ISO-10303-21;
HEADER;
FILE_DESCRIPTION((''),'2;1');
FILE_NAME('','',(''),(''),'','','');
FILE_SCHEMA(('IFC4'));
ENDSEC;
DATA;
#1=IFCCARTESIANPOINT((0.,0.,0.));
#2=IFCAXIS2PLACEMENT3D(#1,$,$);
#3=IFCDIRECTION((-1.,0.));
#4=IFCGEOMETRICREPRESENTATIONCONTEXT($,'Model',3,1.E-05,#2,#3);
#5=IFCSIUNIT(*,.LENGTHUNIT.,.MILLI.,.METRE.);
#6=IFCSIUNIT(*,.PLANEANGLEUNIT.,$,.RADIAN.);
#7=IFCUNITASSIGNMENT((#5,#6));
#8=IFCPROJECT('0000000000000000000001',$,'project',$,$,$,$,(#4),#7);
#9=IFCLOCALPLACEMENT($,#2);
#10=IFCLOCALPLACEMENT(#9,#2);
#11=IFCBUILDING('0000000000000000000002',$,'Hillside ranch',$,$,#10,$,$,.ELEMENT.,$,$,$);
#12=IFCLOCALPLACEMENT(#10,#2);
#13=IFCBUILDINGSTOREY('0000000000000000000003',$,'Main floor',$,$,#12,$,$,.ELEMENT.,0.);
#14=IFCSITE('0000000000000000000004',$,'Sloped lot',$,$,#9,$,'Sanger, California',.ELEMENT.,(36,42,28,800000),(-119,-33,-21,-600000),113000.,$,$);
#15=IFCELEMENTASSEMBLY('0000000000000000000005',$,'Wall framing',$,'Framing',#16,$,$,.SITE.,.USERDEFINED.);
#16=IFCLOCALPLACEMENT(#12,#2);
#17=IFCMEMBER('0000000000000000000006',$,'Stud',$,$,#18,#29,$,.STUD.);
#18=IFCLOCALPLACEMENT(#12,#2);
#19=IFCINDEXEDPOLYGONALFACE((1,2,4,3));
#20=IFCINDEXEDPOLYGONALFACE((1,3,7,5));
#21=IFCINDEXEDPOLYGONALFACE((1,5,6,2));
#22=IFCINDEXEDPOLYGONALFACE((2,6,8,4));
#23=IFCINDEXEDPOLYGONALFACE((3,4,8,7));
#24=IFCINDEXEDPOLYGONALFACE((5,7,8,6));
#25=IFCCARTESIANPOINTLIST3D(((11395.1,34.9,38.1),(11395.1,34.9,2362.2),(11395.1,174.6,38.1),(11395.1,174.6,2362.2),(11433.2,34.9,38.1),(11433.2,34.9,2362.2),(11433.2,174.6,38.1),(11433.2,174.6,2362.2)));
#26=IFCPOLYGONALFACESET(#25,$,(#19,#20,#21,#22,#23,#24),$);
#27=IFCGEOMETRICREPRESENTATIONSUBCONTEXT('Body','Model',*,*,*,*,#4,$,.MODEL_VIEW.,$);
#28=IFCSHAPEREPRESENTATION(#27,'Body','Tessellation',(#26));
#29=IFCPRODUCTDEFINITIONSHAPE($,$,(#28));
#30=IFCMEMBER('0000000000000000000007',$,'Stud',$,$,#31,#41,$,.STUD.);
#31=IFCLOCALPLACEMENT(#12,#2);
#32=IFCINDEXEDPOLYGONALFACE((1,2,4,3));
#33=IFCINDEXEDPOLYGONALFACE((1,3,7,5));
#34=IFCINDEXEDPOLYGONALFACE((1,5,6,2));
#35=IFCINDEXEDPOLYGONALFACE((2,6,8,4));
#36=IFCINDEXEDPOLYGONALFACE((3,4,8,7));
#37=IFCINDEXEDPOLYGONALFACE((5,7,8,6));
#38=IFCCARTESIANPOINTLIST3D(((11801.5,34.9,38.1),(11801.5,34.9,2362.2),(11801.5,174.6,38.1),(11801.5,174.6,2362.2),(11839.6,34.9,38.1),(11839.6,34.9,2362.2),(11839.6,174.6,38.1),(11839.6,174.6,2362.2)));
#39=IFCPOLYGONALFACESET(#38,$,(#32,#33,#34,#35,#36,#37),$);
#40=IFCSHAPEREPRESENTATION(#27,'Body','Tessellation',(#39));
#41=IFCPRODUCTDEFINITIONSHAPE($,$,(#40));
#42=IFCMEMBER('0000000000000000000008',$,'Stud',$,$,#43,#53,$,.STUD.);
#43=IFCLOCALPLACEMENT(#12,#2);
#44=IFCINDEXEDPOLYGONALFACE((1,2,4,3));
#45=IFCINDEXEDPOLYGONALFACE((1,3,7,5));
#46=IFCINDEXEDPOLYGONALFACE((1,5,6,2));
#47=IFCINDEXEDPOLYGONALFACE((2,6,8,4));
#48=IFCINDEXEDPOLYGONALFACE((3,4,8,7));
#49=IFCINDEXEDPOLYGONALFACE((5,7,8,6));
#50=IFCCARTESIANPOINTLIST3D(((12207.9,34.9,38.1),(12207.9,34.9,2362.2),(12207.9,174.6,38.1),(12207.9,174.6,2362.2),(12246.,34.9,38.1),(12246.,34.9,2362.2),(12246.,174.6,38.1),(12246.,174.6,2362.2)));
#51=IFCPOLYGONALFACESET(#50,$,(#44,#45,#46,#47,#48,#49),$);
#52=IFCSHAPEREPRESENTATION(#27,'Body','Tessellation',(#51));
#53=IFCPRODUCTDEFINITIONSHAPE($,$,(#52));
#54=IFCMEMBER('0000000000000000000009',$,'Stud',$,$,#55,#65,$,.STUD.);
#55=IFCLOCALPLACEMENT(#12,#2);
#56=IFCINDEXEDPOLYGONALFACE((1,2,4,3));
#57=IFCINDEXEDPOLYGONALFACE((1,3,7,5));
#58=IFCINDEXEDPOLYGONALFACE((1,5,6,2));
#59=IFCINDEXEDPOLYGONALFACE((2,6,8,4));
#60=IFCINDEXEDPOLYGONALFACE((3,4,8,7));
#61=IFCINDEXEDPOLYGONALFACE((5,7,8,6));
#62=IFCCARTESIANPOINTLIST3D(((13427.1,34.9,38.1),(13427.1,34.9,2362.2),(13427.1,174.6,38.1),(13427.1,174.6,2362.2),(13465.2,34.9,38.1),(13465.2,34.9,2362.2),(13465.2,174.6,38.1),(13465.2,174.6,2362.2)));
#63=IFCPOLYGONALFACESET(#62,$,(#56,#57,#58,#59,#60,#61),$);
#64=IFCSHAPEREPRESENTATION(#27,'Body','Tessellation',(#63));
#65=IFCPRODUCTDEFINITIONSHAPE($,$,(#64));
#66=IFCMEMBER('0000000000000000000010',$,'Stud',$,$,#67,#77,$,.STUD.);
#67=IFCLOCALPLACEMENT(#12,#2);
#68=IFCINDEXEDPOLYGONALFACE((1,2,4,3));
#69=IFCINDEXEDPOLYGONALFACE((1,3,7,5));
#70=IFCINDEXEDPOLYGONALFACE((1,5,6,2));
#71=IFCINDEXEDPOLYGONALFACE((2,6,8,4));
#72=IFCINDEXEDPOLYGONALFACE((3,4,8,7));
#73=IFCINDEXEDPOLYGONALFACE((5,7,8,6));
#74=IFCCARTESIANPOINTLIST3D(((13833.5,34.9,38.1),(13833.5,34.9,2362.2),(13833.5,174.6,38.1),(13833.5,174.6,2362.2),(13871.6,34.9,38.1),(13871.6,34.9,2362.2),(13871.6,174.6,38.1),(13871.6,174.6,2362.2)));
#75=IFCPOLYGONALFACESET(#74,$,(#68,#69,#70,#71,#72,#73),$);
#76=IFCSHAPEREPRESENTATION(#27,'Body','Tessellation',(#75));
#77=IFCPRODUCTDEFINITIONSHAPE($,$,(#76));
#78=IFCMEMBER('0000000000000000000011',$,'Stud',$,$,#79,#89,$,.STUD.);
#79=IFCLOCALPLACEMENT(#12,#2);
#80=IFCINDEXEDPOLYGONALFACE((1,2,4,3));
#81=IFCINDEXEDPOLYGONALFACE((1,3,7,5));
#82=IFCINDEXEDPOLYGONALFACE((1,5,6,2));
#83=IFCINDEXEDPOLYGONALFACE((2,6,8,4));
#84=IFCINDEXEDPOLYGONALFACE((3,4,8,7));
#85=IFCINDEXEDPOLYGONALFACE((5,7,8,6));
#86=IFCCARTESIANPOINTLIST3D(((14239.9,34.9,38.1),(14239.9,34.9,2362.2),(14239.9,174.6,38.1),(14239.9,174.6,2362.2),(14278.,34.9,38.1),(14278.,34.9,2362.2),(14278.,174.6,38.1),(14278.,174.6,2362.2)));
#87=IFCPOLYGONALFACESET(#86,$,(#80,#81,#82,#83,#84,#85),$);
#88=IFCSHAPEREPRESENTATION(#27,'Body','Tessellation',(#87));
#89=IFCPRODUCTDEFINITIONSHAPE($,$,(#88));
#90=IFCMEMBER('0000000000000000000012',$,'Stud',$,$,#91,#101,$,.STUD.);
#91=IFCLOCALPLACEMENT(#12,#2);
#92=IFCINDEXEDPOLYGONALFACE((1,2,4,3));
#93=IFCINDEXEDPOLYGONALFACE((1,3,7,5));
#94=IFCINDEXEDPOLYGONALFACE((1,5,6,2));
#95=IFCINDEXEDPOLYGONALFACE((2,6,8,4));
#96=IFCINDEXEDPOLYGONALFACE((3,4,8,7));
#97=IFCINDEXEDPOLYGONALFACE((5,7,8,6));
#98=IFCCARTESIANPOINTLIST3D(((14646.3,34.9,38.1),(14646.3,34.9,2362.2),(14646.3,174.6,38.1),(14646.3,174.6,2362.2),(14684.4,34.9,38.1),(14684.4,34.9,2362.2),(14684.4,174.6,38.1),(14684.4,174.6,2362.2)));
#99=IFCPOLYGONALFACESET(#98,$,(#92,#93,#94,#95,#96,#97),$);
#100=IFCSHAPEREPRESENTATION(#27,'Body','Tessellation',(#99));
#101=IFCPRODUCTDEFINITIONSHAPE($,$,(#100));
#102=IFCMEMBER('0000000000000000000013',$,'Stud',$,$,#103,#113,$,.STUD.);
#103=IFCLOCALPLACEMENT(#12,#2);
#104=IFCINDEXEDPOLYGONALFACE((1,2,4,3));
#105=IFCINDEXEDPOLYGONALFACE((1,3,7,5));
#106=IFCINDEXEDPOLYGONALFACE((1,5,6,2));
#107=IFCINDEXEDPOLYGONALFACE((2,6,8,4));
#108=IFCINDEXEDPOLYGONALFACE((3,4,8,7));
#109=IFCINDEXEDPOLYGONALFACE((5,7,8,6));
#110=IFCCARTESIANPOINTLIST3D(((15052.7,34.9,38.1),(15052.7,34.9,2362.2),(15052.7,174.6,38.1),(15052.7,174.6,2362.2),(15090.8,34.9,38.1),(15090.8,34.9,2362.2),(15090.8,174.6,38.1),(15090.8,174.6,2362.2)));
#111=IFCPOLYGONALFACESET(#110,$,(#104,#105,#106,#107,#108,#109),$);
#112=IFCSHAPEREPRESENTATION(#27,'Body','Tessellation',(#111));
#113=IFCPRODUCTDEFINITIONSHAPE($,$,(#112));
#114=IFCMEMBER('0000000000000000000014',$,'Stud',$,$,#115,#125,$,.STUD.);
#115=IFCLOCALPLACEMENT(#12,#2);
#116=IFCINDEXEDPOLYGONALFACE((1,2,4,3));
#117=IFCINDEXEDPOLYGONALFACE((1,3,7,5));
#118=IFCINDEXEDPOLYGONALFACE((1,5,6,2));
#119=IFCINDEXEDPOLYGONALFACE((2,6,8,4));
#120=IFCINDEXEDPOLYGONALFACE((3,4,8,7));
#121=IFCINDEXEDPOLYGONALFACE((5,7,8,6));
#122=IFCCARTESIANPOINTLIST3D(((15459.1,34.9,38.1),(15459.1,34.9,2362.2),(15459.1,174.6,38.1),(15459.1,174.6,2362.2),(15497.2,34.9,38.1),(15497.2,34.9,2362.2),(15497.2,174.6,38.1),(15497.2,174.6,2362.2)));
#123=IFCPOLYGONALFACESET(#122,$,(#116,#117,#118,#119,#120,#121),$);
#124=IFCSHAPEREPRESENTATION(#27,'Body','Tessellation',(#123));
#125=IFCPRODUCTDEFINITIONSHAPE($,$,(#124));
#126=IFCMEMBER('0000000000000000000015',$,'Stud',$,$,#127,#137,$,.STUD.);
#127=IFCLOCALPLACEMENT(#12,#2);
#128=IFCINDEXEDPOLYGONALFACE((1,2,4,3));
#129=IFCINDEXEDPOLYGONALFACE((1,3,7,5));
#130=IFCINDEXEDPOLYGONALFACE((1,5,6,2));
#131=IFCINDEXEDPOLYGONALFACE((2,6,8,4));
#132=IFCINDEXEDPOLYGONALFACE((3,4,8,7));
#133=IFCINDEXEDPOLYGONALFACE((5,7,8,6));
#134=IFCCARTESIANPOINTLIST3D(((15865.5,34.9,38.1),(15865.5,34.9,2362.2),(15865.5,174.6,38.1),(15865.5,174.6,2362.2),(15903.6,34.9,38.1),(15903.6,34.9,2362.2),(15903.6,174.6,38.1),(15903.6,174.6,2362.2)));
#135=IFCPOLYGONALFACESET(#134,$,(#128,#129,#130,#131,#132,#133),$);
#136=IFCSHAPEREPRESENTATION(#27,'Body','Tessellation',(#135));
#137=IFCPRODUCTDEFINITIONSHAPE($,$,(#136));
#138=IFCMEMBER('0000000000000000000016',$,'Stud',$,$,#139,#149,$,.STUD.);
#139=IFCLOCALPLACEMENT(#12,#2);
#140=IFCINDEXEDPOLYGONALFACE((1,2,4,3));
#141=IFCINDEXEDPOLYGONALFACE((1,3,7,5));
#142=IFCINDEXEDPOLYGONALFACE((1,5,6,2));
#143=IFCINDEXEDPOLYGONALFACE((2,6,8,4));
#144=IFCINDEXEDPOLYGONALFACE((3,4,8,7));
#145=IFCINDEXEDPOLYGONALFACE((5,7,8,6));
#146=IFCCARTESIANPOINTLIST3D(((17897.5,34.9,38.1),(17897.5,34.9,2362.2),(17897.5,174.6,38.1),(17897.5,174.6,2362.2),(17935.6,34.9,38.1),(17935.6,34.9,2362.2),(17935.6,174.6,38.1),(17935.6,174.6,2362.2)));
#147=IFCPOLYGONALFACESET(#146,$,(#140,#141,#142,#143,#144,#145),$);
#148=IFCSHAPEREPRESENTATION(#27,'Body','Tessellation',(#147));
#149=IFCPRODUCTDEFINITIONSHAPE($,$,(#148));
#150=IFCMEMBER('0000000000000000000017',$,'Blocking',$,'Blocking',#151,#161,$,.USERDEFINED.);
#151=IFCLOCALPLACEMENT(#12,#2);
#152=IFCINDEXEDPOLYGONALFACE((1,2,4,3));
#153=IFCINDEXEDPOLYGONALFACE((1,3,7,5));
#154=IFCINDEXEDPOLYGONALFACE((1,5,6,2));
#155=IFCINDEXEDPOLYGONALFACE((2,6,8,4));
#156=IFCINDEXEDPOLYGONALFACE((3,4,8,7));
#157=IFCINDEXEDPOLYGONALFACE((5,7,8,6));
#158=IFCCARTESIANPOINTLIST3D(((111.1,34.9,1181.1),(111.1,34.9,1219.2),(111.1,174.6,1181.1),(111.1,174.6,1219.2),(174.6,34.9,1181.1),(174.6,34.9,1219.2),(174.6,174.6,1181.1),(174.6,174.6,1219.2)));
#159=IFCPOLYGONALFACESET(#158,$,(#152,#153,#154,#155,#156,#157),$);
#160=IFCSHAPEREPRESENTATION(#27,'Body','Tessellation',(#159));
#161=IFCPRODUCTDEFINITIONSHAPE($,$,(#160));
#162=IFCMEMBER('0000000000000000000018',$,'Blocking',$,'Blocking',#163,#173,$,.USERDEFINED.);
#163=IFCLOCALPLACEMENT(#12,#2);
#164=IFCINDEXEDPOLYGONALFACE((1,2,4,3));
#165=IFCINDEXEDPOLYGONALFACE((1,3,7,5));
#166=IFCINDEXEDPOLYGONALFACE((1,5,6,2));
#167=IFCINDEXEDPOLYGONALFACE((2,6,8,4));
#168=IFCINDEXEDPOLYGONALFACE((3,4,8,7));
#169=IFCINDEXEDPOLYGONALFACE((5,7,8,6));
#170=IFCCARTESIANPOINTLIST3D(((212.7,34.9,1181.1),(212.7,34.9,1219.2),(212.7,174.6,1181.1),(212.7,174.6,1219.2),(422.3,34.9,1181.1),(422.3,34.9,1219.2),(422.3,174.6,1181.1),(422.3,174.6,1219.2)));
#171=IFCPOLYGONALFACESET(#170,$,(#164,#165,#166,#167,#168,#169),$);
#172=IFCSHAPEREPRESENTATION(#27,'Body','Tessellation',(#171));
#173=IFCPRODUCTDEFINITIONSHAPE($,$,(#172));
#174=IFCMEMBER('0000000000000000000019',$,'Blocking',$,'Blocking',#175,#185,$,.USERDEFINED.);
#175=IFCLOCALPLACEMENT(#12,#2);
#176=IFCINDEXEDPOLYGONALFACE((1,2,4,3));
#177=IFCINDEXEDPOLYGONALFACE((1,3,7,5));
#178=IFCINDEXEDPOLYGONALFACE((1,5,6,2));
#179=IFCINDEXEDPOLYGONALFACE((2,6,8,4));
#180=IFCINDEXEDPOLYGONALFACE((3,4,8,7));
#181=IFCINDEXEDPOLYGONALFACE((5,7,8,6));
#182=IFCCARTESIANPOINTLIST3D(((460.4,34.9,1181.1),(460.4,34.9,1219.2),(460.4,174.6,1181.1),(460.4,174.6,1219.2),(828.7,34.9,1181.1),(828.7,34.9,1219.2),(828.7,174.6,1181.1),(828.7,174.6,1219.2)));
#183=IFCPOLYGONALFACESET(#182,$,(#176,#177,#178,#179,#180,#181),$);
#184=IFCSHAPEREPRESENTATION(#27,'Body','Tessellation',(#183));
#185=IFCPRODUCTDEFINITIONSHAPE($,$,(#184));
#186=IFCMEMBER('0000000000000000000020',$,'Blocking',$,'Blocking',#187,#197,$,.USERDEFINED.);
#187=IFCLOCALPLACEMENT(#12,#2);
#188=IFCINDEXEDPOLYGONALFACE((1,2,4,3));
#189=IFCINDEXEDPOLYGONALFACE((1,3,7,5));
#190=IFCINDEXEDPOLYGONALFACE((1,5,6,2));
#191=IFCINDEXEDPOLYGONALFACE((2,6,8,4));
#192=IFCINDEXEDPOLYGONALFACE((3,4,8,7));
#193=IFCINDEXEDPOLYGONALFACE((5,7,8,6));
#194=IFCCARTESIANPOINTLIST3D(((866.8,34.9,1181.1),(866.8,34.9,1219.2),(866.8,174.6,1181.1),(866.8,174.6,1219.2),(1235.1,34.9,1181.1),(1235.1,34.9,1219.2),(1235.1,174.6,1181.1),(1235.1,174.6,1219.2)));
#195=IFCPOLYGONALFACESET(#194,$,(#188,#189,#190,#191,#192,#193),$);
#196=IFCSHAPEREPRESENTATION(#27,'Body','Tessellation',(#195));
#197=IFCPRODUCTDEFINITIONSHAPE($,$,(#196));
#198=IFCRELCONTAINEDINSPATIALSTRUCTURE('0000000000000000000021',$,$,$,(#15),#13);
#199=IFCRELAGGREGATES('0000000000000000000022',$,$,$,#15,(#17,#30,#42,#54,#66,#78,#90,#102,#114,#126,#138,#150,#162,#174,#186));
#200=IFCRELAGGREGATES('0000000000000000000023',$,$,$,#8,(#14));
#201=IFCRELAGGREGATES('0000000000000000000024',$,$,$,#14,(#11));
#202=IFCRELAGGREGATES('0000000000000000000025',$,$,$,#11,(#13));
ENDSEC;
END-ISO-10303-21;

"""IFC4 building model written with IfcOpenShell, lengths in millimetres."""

from ifc_helpers import new_model, si_unit, direction, frame, origin, origin_with_axes, place, context, subcontext, project, spatial, polyline, outline, extrude, element, aggregate, save


model = new_model("IFC4")

# Units and contexts
model_context = context("Model", 3, precision=1e-05, world=origin(), true_north=direction((-1.0, 0.0)))
body_context = subcontext(model_context, "Body", "Model", "MODEL_VIEW")
ifc_project = project(units=[si_unit("LENGTHUNIT", "METRE", prefix="MILLI"), si_unit("PLANEANGLEUNIT", "RADIAN")], contexts=[model_context])

# Site, building, storey
site_placement = place(None, origin())
site = spatial("IfcSite", under=ifc_project, at=site_placement, Name="Sloped lot", LongName="Sanger, California", CompositionType="ELEMENT", RefLatitude=(36, 42, 28, 800000), RefLongitude=(-119, -33, -21, -600000), RefElevation=113000.0)
building_placement = place(site_placement, origin())
building = spatial("IfcBuilding", under=site, at=building_placement, Name="Hillside ranch", CompositionType="ELEMENT")
storey_placement = place(building_placement, origin())
storey = spatial("IfcBuildingStorey", under=building, at=storey_placement, Name="Main floor", CompositionType="ELEMENT", Elevation=0.0)

# Element assembly, members
assembly_placement = place(storey_placement, origin_with_axes())
assembly = element("IfcElementAssembly", 1, at=assembly_placement, inside=storey, Name="Wall framing", ObjectType="Framing", AssemblyPlace="SITE", PredefinedType="USERDEFINED")
member_1_placement = place(storey_placement, origin_with_axes())
member_1 = element("IfcMember", 2, at=member_1_placement, Name="Stud", PredefinedType="STUD", context=body_context, shape_type="SweptSolid", body=[
    extrude(outline(polyline([(0.0, 0.0), (38.1, 0.0), (38.1, 139.7), (0.0, 139.7), (0.0, 0.0)])), frame((11395.1, 34.9, 38.1), z_axis=(0.0, 0.0, 1.0), x_axis=(1.0, 0.0, 0.0)), (0.0, 0.0, 1.0), 2324.1),
])
member_2_placement = place(storey_placement, origin_with_axes())
member_2 = element("IfcMember", 3, at=member_2_placement, Name="Stud", PredefinedType="STUD", context=body_context, shape_type="SweptSolid", body=[
    extrude(outline(polyline([(0.0, 0.0), (38.1, 0.0), (38.1, 139.7), (0.0, 139.7), (0.0, 0.0)])), frame((11801.5, 34.9, 38.1), z_axis=(0.0, 0.0, 1.0), x_axis=(1.0, 0.0, 0.0)), (0.0, 0.0, 1.0), 2324.1),
])
member_3_placement = place(storey_placement, origin_with_axes())
member_3 = element("IfcMember", 4, at=member_3_placement, Name="Stud", PredefinedType="STUD", context=body_context, shape_type="SweptSolid", body=[
    extrude(outline(polyline([(0.0, 0.0), (38.1, 0.0), (38.1, 139.7), (0.0, 139.7), (0.0, 0.0)])), frame((12207.9, 34.9, 38.1), z_axis=(0.0, 0.0, 1.0), x_axis=(1.0, 0.0, 0.0)), (0.0, 0.0, 1.0), 2324.1),
])
member_4_placement = place(storey_placement, origin_with_axes())
member_4 = element("IfcMember", 5, at=member_4_placement, Name="Stud", PredefinedType="STUD", context=body_context, shape_type="SweptSolid", body=[
    extrude(outline(polyline([(0.0, 0.0), (38.1, 0.0), (38.1, 139.7), (0.0, 139.7), (0.0, 0.0)])), frame((13427.1, 34.9, 38.1), z_axis=(0.0, 0.0, 1.0), x_axis=(1.0, 0.0, 0.0)), (0.0, 0.0, 1.0), 2324.1),
])
member_5_placement = place(storey_placement, origin_with_axes())
member_5 = element("IfcMember", 6, at=member_5_placement, Name="Stud", PredefinedType="STUD", context=body_context, shape_type="SweptSolid", body=[
    extrude(outline(polyline([(0.0, 0.0), (38.1, 0.0), (38.1, 139.7), (0.0, 139.7), (0.0, 0.0)])), frame((13833.5, 34.9, 38.1), z_axis=(0.0, 0.0, 1.0), x_axis=(1.0, 0.0, 0.0)), (0.0, 0.0, 1.0), 2324.1),
])
member_6_placement = place(storey_placement, origin_with_axes())
member_6 = element("IfcMember", 7, at=member_6_placement, Name="Stud", PredefinedType="STUD", context=body_context, shape_type="SweptSolid", body=[
    extrude(outline(polyline([(0.0, 0.0), (38.1, 0.0), (38.1, 139.7), (0.0, 139.7), (0.0, 0.0)])), frame((14239.9, 34.9, 38.1), z_axis=(0.0, 0.0, 1.0), x_axis=(1.0, 0.0, 0.0)), (0.0, 0.0, 1.0), 2324.1),
])
member_7_placement = place(storey_placement, origin_with_axes())
member_7 = element("IfcMember", 8, at=member_7_placement, Name="Stud", PredefinedType="STUD", context=body_context, shape_type="SweptSolid", body=[
    extrude(outline(polyline([(0.0, 0.0), (38.1, 0.0), (38.1, 139.7), (0.0, 139.7), (0.0, 0.0)])), frame((14646.3, 34.9, 38.1), z_axis=(0.0, 0.0, 1.0), x_axis=(1.0, 0.0, 0.0)), (0.0, 0.0, 1.0), 2324.1),
])
member_8_placement = place(storey_placement, origin_with_axes())
member_8 = element("IfcMember", 9, at=member_8_placement, Name="Stud", PredefinedType="STUD", context=body_context, shape_type="SweptSolid", body=[
    extrude(outline(polyline([(0.0, 0.0), (38.1, 0.0), (38.1, 139.7), (0.0, 139.7), (0.0, 0.0)])), frame((15052.7, 34.9, 38.1), z_axis=(0.0, 0.0, 1.0), x_axis=(1.0, 0.0, 0.0)), (0.0, 0.0, 1.0), 2324.1),
])
member_9_placement = place(storey_placement, origin_with_axes())
member_9 = element("IfcMember", 10, at=member_9_placement, Name="Stud", PredefinedType="STUD", context=body_context, shape_type="SweptSolid", body=[
    extrude(outline(polyline([(0.0, 0.0), (38.1, 0.0), (38.1, 139.7), (0.0, 139.7), (0.0, 0.0)])), frame((15459.1, 34.9, 38.1), z_axis=(0.0, 0.0, 1.0), x_axis=(1.0, 0.0, 0.0)), (0.0, 0.0, 1.0), 2324.1),
])
member_10_placement = place(storey_placement, origin_with_axes())
member_10 = element("IfcMember", 11, at=member_10_placement, Name="Stud", PredefinedType="STUD", context=body_context, shape_type="SweptSolid", body=[
    extrude(outline(polyline([(0.0, 0.0), (38.1, 0.0), (38.1, 139.7), (0.0, 139.7), (0.0, 0.0)])), frame((15865.5, 34.9, 38.1), z_axis=(0.0, 0.0, 1.0), x_axis=(1.0, 0.0, 0.0)), (0.0, 0.0, 1.0), 2324.1),
])
member_11_placement = place(storey_placement, origin_with_axes())
member_11 = element("IfcMember", 12, at=member_11_placement, Name="Stud", PredefinedType="STUD", context=body_context, shape_type="SweptSolid", body=[
    extrude(outline(polyline([(0.0, 0.0), (38.1, 0.0), (38.1, 139.7), (0.0, 139.7), (0.0, 0.0)])), frame((17897.5, 34.9, 38.1), z_axis=(0.0, 0.0, 1.0), x_axis=(1.0, 0.0, 0.0)), (0.0, 0.0, 1.0), 2324.1),
])
member_12_placement = place(storey_placement, origin_with_axes())
member_12 = element("IfcMember", 13, at=member_12_placement, Name="Blocking", ObjectType="Blocking", PredefinedType="USERDEFINED", context=body_context, shape_type="SweptSolid", body=[
    extrude(outline(polyline([(0.0, 0.0), (63.5, 0.0), (63.5, 139.7), (0.0, 139.7), (0.0, 0.0)])), frame((111.1, 34.9, 1181.1), z_axis=(0.0, 0.0, 1.0), x_axis=(1.0, 0.0, 0.0)), (0.0, 0.0, 1.0), 38.1),
])
member_13_placement = place(storey_placement, origin_with_axes())
member_13 = element("IfcMember", 14, at=member_13_placement, Name="Blocking", ObjectType="Blocking", PredefinedType="USERDEFINED", context=body_context, shape_type="SweptSolid", body=[
    extrude(outline(polyline([(0.0, 0.0), (209.6, 0.0), (209.6, 139.7), (0.0, 139.7), (0.0, 0.0)])), frame((212.7, 34.9, 1181.1), z_axis=(0.0, 0.0, 1.0), x_axis=(1.0, 0.0, 0.0)), (0.0, 0.0, 1.0), 38.1),
])
member_14_placement = place(storey_placement, origin_with_axes())
member_14 = element("IfcMember", 15, at=member_14_placement, Name="Blocking", ObjectType="Blocking", PredefinedType="USERDEFINED", context=body_context, shape_type="SweptSolid", body=[
    extrude(outline(polyline([(0.0, 0.0), (368.3, 0.0), (368.3, 139.7), (0.0, 139.7), (0.0, 0.0)])), frame((460.4, 34.9, 1181.1), z_axis=(0.0, 0.0, 1.0), x_axis=(1.0, 0.0, 0.0)), (0.0, 0.0, 1.0), 38.1),
])
member_15_placement = place(storey_placement, origin_with_axes())
member_15 = element("IfcMember", 16, at=member_15_placement, Name="Blocking", ObjectType="Blocking", PredefinedType="USERDEFINED", context=body_context, shape_type="SweptSolid", body=[
    extrude(outline(polyline([(0.0, 0.0), (368.3, 0.0), (368.3, 139.7), (0.0, 139.7), (0.0, 0.0)])), frame((866.8, 34.9, 1181.1), z_axis=(0.0, 0.0, 1.0), x_axis=(1.0, 0.0, 0.0)), (0.0, 0.0, 1.0), 38.1),
])
aggregate(assembly, [member_1, member_2, member_3, member_4, member_5, member_6, member_7, member_8, member_9, member_10, member_11, member_12, member_13, member_14, member_15])

save(model, "model.ifc")
